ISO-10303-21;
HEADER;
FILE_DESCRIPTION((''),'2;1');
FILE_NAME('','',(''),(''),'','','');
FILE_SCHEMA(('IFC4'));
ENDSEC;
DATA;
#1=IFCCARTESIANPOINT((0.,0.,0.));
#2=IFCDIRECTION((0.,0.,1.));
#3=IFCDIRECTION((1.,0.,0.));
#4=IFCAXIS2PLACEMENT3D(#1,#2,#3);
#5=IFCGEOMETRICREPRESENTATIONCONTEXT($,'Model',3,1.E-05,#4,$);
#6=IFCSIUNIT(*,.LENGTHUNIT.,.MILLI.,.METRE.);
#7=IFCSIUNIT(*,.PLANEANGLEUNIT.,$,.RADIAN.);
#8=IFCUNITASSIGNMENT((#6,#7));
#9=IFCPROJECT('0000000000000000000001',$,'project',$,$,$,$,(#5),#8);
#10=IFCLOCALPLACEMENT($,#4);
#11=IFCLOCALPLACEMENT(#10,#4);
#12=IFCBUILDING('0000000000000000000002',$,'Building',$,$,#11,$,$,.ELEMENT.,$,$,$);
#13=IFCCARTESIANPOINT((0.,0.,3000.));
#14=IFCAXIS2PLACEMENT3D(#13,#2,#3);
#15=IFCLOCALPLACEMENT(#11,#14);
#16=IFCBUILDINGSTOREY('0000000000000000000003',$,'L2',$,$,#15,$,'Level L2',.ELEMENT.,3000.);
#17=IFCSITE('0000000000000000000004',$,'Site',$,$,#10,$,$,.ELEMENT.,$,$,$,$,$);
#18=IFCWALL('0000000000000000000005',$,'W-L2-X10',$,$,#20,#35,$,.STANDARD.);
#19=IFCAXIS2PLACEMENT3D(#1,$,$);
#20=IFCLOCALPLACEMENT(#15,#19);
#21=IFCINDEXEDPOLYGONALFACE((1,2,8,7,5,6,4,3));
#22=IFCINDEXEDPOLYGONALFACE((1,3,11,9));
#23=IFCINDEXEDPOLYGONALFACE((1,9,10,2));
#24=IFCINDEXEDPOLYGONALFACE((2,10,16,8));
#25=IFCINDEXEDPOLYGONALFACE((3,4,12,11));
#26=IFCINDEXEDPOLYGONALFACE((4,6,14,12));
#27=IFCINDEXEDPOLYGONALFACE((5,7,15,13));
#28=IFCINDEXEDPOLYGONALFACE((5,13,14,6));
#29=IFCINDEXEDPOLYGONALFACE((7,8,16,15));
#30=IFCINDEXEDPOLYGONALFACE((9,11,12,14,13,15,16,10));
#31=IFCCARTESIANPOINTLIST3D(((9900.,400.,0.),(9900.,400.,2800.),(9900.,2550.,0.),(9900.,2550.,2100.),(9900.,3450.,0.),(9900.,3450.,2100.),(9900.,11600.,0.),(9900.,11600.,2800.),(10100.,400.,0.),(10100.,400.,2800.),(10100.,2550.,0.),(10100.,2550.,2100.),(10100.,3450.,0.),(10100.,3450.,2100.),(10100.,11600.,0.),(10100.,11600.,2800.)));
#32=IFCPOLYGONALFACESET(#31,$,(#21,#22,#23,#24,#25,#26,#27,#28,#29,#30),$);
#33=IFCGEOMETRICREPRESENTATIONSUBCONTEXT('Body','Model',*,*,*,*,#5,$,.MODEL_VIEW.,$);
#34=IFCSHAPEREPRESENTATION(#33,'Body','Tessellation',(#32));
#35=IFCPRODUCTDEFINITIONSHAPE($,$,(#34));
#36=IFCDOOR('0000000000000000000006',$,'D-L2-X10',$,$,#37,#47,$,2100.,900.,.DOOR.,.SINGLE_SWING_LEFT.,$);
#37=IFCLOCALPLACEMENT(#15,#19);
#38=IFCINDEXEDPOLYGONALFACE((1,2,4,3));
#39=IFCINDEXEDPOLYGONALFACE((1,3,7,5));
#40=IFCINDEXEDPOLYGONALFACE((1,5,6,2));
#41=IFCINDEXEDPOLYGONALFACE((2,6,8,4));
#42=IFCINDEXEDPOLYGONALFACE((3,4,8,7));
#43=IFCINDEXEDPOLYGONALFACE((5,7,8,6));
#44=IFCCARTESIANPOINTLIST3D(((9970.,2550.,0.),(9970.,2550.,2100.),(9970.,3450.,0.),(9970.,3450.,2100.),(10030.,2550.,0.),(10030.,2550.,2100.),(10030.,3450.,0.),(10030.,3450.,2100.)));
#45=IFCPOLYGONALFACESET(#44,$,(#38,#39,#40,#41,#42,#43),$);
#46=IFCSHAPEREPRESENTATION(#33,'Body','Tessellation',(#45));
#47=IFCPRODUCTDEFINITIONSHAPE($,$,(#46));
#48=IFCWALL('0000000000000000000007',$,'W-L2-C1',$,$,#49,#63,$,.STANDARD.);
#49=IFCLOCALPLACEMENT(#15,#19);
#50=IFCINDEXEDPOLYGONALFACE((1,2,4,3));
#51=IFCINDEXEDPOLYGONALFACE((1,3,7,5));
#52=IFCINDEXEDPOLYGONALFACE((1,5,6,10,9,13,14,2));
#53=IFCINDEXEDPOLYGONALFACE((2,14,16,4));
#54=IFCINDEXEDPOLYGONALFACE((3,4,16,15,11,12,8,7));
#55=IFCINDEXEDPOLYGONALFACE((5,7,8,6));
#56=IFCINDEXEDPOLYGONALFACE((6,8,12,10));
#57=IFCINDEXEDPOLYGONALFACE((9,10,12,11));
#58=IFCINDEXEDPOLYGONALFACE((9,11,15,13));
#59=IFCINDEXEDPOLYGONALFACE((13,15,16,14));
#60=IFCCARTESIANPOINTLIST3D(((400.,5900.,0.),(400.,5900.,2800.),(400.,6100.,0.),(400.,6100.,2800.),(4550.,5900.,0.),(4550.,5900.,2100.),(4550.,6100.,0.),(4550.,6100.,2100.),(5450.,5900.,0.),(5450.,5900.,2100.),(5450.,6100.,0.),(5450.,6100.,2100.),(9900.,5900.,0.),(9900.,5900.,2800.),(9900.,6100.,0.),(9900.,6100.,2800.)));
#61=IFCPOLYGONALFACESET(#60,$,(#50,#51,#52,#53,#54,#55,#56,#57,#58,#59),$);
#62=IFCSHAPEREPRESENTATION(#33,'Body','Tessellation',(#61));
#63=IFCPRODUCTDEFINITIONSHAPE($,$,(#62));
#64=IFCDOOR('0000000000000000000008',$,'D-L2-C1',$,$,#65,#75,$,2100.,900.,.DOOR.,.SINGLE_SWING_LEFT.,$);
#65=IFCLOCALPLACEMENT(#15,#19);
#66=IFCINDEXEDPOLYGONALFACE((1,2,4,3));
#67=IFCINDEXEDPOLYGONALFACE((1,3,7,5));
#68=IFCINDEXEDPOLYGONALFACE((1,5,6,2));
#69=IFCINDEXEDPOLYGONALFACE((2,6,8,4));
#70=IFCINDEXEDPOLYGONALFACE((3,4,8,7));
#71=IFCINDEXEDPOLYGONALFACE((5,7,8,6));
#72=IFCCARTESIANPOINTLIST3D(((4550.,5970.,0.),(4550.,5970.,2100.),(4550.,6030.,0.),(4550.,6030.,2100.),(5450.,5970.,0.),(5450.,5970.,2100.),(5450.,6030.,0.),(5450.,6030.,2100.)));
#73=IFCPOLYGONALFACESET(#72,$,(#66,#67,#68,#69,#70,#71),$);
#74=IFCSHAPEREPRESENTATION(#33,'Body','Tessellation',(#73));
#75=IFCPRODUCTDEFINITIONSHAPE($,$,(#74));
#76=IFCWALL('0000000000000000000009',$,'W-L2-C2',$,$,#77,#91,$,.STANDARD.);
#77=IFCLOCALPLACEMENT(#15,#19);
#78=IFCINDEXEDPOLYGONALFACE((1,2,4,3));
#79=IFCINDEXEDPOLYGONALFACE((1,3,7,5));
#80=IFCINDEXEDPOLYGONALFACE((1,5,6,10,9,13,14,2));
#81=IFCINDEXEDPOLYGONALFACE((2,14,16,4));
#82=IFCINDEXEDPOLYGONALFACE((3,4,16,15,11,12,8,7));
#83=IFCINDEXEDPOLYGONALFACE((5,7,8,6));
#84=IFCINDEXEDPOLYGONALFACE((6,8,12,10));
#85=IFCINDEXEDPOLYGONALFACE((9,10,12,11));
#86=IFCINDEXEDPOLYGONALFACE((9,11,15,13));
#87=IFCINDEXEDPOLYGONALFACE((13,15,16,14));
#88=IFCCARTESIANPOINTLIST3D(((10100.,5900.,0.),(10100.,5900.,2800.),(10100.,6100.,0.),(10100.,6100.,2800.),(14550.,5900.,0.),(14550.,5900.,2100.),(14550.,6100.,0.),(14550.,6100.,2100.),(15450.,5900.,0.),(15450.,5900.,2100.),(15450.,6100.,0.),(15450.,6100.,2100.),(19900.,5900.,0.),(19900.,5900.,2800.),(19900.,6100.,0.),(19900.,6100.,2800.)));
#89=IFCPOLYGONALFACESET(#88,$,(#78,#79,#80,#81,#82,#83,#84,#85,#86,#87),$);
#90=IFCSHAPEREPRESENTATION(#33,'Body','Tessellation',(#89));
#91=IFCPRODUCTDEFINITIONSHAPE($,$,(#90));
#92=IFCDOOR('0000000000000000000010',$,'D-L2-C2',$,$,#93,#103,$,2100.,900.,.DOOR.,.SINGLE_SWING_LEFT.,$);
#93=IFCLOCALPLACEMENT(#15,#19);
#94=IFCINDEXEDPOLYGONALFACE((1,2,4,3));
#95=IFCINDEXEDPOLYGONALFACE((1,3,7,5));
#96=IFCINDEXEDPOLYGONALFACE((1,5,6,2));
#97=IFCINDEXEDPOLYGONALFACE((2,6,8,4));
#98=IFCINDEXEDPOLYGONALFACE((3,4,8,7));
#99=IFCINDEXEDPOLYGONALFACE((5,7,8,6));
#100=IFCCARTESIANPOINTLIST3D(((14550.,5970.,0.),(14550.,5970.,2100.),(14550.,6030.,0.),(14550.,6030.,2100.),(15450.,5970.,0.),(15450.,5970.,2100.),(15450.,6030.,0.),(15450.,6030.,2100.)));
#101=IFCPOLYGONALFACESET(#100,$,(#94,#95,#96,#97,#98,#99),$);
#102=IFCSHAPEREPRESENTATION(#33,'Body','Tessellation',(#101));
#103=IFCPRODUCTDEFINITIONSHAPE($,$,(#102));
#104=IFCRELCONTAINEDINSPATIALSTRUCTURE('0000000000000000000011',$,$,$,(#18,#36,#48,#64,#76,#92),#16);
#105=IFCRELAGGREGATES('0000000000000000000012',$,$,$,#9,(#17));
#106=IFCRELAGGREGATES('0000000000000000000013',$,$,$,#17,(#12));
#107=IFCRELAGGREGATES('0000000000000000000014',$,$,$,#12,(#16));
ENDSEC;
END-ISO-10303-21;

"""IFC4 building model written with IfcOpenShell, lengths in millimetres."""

from ifc_helpers import new_model, si_unit, frame, origin_with_axes, origin_2d, place, context, subcontext, project, spatial, rectangle, extrude, element, fill, save


model = new_model("IFC4")

# Units and contexts
model_context = context("Model", 3, precision=1e-05, world=origin_with_axes())
body_context = subcontext(model_context, "Body", "Model", "MODEL_VIEW")
ifc_project = project(units=[si_unit("LENGTHUNIT", "METRE", prefix="MILLI"), si_unit("PLANEANGLEUNIT", "RADIAN")], contexts=[model_context])

# Site, building, storey
site_placement = place(None, origin_with_axes())
site = spatial("IfcSite", under=ifc_project, at=site_placement, Name="Site", CompositionType="ELEMENT")
building_placement = place(site_placement, origin_with_axes())
building = spatial("IfcBuilding", under=site, at=building_placement, Name="Building", CompositionType="ELEMENT")
storey_placement = place(building_placement, frame((0.0, 0.0, 3000.0), z_axis=(0.0, 0.0, 1.0), x_axis=(1.0, 0.0, 0.0)))
storey = spatial("IfcBuildingStorey", under=building, at=storey_placement, Name="L2", LongName="Level L2", CompositionType="ELEMENT", Elevation=3000.0)

# Walls, openings, doors
wall_1_placement = place(storey_placement, frame((10000.0, 6000.0, 0.0), z_axis=(0.0, 0.0, 1.0), x_axis=(1.0, 0.0, 0.0)))
wall_1 = element("IfcWall", 1, at=wall_1_placement, inside=storey, Name="W-L2-X10", PredefinedType="STANDARD", context=body_context, shape_type="SweptSolid", body=[
    extrude(rectangle(XDim=200.0, YDim=11200.0, at=origin_2d()), origin_with_axes(), (0.0, 0.0, 1.0), 2800.0),
])
opening_1_placement = place(wall_1_placement, frame((0.0, -3000.0, 0.0), z_axis=(0.0, 0.0, 1.0), x_axis=(1.0, 0.0, 0.0)))
opening_1 = element("IfcOpeningElement", 2, at=opening_1_placement, cuts=wall_1, PredefinedType="OPENING", context=body_context, shape_type="SweptSolid", body=[
    extrude(rectangle(XDim=300.0, YDim=900.0, at=origin_2d()), origin_with_axes(), (0.0, 0.0, 1.0), 2100.0),
])
door_1_placement = place(wall_1_placement, frame((0.0, -3000.0, 0.0), z_axis=(0.0, 0.0, 1.0), x_axis=(1.0, 0.0, 0.0)))
door_1 = element("IfcDoor", 3, at=door_1_placement, inside=storey, Name="D-L2-X10", OperationType="SINGLE_SWING_LEFT", OverallHeight=2100.0, OverallWidth=900.0, PredefinedType="DOOR", context=body_context, shape_type="SweptSolid", body=[
    extrude(rectangle(XDim=60.0, YDim=900.0, at=origin_2d()), origin_with_axes(), (0.0, 0.0, 1.0), 2100.0),
])
fill(opening_1, door_1)
wall_2_placement = place(storey_placement, frame((5150.0, 6000.0, 0.0), z_axis=(0.0, 0.0, 1.0), x_axis=(1.0, 0.0, 0.0)))
wall_2 = element("IfcWall", 4, at=wall_2_placement, inside=storey, Name="W-L2-C1", PredefinedType="STANDARD", context=body_context, shape_type="SweptSolid", body=[
    extrude(rectangle(XDim=9500.0, YDim=200.0, at=origin_2d()), origin_with_axes(), (0.0, 0.0, 1.0), 2800.0),
])
opening_2_placement = place(wall_2_placement, frame((-150.0, 0.0, 0.0), z_axis=(0.0, 0.0, 1.0), x_axis=(1.0, 0.0, 0.0)))
opening_2 = element("IfcOpeningElement", 5, at=opening_2_placement, cuts=wall_2, PredefinedType="OPENING", context=body_context, shape_type="SweptSolid", body=[
    extrude(rectangle(XDim=900.0, YDim=300.0, at=origin_2d()), origin_with_axes(), (0.0, 0.0, 1.0), 2100.0),
])
door_2_placement = place(wall_2_placement, frame((-150.0, 0.0, 0.0), z_axis=(0.0, 0.0, 1.0), x_axis=(1.0, 0.0, 0.0)))
door_2 = element("IfcDoor", 6, at=door_2_placement, inside=storey, Name="D-L2-C1", OperationType="SINGLE_SWING_LEFT", OverallHeight=2100.0, OverallWidth=900.0, PredefinedType="DOOR", context=body_context, shape_type="SweptSolid", body=[
    extrude(rectangle(XDim=900.0, YDim=60.0, at=origin_2d()), origin_with_axes(), (0.0, 0.0, 1.0), 2100.0),
])
fill(opening_2, door_2)
wall_3_placement = place(storey_placement, frame((15000.0, 6000.0, 0.0), z_axis=(0.0, 0.0, 1.0), x_axis=(1.0, 0.0, 0.0)))
wall_3 = element("IfcWall", 7, at=wall_3_placement, inside=storey, Name="W-L2-C2", PredefinedType="STANDARD", context=body_context, shape_type="SweptSolid", body=[
    extrude(rectangle(XDim=9800.0, YDim=200.0, at=origin_2d()), origin_with_axes(), (0.0, 0.0, 1.0), 2800.0),
])
opening_3_placement = place(wall_3_placement, origin_with_axes())
opening_3 = element("IfcOpeningElement", 8, at=opening_3_placement, cuts=wall_3, PredefinedType="OPENING", context=body_context, shape_type="SweptSolid", body=[
    extrude(rectangle(XDim=900.0, YDim=300.0, at=origin_2d()), origin_with_axes(), (0.0, 0.0, 1.0), 2100.0),
])
door_3_placement = place(wall_3_placement, origin_with_axes())
door_3 = element("IfcDoor", 9, at=door_3_placement, inside=storey, Name="D-L2-C2", OperationType="SINGLE_SWING_LEFT", OverallHeight=2100.0, OverallWidth=900.0, PredefinedType="DOOR", context=body_context, shape_type="SweptSolid", body=[
    extrude(rectangle(XDim=900.0, YDim=60.0, at=origin_2d()), origin_with_axes(), (0.0, 0.0, 1.0), 2100.0),
])
fill(opening_3, door_3)

save(model, "model.ifc")
